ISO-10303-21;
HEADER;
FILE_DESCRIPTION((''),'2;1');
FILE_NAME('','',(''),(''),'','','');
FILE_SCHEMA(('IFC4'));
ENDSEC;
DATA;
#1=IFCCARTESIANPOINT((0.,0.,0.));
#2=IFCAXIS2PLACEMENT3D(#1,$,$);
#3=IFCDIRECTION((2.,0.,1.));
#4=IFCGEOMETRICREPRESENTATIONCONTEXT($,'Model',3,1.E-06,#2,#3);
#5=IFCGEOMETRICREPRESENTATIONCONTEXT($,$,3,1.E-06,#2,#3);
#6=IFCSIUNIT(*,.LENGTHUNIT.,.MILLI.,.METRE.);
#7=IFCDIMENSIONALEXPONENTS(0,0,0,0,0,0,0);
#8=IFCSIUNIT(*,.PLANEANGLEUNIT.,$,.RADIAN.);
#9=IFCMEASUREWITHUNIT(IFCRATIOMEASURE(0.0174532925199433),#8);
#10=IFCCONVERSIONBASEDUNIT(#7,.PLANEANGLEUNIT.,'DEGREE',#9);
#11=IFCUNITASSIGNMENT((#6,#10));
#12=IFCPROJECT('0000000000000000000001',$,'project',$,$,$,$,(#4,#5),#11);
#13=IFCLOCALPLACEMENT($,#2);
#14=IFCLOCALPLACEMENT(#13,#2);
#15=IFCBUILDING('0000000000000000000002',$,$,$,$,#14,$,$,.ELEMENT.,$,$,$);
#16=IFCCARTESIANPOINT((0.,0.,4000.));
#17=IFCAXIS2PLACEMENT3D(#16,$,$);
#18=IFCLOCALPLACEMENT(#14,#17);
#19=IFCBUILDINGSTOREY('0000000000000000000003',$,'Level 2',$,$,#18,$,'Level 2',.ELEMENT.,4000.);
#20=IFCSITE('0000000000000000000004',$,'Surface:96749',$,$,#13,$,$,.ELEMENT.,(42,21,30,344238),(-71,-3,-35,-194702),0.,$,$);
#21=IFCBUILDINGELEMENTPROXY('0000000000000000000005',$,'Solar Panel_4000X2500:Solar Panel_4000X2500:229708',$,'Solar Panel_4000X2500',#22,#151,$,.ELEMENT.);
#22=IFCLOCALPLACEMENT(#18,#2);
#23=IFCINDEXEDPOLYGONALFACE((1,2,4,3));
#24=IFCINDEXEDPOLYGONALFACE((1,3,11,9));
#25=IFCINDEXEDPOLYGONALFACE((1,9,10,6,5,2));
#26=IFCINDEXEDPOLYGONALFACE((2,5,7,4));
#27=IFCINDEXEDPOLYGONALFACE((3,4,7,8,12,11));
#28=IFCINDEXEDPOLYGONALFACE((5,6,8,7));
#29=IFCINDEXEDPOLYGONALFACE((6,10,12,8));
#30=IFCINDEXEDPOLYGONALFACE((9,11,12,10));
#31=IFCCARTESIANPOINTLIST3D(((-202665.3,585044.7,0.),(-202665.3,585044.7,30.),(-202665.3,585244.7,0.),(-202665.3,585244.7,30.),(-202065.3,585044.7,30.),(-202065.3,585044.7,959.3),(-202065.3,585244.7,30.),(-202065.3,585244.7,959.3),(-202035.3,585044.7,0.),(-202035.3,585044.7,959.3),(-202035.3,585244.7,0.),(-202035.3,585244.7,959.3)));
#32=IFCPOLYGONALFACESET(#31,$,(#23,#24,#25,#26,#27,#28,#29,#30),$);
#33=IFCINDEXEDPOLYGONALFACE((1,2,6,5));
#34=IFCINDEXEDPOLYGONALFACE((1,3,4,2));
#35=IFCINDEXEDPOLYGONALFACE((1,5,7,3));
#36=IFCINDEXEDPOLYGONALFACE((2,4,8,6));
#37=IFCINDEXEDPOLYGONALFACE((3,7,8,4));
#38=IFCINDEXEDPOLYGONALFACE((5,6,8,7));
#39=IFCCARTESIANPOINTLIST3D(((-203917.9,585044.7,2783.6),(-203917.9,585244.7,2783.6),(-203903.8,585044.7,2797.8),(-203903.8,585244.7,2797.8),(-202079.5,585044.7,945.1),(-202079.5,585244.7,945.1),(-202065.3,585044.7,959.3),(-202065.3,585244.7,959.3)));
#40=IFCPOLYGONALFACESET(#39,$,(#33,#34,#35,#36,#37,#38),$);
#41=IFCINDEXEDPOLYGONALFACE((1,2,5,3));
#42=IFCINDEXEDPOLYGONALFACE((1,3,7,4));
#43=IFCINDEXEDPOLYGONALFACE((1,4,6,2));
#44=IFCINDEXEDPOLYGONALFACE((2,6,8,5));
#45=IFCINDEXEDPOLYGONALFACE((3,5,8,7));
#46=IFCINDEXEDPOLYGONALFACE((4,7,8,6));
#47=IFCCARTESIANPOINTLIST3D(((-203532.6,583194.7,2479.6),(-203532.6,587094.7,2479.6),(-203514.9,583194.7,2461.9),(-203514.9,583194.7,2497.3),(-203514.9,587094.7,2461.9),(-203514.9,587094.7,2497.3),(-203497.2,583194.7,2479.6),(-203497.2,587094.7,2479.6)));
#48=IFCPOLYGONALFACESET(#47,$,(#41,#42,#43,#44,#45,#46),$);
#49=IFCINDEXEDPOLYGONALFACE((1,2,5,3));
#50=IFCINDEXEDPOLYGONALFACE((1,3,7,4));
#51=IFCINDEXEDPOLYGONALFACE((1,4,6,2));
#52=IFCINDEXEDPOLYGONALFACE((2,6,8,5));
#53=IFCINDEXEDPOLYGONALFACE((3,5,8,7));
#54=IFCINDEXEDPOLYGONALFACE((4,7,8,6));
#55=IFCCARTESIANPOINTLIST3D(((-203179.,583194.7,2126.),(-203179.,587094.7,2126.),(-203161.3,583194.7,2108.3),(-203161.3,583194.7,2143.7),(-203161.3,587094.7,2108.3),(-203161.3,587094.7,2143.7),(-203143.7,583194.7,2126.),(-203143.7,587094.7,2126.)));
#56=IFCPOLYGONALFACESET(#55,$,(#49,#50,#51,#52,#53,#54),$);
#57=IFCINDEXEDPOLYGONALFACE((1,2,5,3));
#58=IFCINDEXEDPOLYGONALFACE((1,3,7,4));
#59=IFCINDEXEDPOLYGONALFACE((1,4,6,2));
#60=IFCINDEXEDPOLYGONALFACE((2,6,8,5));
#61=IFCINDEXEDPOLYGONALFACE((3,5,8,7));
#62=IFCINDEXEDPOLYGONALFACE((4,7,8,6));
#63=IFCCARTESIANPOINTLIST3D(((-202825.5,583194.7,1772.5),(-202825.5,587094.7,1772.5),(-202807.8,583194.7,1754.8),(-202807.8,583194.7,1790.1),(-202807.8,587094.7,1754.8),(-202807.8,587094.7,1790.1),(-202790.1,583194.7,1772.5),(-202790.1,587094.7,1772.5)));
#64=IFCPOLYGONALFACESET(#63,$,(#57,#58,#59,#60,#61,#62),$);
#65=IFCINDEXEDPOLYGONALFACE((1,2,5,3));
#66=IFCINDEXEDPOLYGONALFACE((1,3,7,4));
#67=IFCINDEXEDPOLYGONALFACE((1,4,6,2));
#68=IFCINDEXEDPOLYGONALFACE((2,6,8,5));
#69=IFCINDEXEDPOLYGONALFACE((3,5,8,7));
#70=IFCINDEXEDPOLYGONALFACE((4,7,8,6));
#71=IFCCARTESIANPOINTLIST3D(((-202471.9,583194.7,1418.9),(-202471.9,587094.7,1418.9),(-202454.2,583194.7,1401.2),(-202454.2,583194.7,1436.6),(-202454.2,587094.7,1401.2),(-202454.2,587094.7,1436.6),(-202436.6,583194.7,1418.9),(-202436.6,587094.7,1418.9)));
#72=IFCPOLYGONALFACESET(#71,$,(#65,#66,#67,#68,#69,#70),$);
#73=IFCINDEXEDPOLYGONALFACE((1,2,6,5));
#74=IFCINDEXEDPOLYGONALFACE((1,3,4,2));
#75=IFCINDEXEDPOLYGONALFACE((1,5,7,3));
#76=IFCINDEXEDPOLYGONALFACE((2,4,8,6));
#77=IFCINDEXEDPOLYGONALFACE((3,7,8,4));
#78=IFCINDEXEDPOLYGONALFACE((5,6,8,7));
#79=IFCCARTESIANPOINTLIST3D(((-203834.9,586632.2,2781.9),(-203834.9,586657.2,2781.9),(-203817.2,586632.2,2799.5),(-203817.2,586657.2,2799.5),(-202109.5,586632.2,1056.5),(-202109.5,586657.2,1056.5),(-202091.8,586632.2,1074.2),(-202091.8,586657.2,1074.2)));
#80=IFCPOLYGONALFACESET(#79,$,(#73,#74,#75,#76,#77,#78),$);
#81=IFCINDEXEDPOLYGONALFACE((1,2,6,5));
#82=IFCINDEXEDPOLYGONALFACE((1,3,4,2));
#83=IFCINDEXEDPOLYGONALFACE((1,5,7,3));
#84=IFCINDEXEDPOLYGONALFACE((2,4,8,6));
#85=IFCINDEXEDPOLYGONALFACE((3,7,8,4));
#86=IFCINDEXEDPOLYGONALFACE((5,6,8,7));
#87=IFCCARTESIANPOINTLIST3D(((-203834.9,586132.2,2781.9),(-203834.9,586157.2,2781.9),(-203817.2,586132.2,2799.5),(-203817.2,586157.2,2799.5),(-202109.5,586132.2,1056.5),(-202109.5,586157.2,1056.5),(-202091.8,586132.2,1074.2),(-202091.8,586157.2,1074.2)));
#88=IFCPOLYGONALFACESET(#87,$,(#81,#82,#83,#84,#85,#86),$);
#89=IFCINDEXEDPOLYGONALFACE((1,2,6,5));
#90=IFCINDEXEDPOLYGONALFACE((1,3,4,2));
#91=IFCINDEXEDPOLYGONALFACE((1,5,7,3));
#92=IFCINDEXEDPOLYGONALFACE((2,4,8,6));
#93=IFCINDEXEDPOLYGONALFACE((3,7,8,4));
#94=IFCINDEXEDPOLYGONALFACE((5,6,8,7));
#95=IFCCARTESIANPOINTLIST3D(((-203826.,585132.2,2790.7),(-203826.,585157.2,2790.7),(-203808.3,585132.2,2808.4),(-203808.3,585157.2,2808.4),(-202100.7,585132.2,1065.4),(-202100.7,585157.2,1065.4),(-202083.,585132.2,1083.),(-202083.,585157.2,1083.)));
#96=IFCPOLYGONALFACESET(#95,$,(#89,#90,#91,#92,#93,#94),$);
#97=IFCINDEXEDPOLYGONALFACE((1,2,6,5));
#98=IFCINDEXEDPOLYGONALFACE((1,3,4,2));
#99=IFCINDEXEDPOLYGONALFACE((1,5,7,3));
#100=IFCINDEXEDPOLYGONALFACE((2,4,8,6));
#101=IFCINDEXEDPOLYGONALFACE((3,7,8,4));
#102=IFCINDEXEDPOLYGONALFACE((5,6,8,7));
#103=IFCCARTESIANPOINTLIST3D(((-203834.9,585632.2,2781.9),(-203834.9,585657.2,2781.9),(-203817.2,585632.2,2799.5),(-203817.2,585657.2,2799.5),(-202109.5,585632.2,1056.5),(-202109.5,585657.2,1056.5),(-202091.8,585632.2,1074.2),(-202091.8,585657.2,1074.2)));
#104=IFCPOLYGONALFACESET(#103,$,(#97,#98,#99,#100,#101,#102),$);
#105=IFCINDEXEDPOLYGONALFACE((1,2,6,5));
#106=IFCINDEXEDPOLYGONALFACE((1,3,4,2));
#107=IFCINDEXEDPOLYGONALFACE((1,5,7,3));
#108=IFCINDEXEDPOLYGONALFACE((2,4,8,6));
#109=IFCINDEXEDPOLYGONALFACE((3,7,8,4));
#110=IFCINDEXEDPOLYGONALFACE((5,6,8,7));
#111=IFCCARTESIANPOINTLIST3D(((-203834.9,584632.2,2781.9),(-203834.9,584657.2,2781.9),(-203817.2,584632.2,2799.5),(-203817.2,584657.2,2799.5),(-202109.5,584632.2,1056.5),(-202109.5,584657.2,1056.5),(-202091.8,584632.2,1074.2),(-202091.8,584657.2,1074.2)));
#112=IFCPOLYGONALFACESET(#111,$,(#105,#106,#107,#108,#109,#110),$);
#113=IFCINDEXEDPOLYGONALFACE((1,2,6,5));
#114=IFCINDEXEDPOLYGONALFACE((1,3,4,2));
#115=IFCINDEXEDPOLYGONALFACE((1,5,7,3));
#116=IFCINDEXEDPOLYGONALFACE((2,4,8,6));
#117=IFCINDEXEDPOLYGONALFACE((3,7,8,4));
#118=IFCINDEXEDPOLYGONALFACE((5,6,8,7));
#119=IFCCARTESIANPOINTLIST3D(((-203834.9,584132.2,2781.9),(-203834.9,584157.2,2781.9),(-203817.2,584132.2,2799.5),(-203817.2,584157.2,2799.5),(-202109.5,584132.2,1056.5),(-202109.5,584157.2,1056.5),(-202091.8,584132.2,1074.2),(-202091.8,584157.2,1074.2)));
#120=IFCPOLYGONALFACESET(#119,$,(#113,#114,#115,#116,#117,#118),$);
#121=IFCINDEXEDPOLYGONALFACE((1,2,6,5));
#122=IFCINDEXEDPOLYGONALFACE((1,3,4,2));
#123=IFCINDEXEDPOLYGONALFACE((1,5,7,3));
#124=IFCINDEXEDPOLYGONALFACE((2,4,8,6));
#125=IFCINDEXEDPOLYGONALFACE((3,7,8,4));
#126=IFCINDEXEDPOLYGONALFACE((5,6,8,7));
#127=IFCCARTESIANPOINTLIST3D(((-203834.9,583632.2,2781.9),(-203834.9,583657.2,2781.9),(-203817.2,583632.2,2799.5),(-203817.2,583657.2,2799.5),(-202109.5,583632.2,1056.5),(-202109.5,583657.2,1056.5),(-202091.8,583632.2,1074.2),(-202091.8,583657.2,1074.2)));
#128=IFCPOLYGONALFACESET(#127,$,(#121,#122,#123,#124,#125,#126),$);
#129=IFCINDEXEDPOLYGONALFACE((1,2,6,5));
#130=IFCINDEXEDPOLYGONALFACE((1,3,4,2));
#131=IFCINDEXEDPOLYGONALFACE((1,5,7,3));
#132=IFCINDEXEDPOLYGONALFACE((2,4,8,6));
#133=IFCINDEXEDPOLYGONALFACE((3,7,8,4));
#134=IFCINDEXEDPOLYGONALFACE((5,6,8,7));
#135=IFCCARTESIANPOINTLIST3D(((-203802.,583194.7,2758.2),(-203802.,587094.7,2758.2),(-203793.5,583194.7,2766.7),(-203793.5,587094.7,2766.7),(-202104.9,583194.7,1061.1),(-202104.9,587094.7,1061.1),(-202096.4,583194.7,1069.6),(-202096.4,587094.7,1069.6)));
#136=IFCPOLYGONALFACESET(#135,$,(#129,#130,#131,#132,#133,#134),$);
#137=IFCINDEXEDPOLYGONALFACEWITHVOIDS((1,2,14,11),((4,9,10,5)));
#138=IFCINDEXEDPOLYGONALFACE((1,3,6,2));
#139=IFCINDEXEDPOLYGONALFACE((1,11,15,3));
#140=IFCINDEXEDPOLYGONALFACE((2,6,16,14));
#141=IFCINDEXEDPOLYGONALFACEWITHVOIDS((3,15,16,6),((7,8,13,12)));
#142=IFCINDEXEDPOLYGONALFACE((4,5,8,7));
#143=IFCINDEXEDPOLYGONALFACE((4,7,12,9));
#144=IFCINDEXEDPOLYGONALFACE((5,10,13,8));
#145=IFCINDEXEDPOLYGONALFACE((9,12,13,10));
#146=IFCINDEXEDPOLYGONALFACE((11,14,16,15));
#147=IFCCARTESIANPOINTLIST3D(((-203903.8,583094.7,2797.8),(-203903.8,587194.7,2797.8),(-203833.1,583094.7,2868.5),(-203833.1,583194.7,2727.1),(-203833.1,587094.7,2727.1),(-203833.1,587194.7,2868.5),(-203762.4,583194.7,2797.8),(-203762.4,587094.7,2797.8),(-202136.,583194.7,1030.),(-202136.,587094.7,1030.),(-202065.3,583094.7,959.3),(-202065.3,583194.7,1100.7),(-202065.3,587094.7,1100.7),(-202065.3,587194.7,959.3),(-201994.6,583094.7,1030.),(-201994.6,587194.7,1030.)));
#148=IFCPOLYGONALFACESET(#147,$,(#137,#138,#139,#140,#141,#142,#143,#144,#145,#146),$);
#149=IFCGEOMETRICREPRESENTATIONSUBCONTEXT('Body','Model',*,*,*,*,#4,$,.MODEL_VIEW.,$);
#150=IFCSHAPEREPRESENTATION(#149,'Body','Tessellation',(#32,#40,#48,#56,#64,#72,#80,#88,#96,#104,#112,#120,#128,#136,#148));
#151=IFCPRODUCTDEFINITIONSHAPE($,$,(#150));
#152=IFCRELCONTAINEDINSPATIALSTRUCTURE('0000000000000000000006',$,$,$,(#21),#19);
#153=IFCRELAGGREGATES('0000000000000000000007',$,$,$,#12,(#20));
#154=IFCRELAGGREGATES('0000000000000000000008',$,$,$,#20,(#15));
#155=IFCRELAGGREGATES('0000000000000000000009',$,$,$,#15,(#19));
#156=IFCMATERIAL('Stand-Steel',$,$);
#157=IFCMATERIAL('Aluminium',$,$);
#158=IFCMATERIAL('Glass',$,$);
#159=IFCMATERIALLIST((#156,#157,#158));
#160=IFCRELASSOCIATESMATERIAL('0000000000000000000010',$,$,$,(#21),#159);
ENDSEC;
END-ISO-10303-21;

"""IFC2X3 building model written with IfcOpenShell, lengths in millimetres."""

from ifc_helpers import new_model, entity, si_unit, converted_unit, direction, frame, frame_2d, origin, origin_2d_with_axis, place, context, subcontext, project, spatial, polyline, rectangle, outline, extrude, source, transform, mapped, material, material_list, element, save


model = new_model("IFC2X3")

# Units and contexts
model_context = context("Model", 3, precision=1e-06, world=origin(), true_north=direction((2.0, 0.0, 1.0)))
context_of_model = context(None, 3, precision=1e-06, world=origin(), true_north=direction((2.0, 0.0, 1.0)))
body_context = subcontext(model_context, "Body", "Model", "MODEL_VIEW")
ifc_project = project(units=[si_unit("LENGTHUNIT", "METRE", prefix="MILLI"), converted_unit("PLANEANGLEUNIT", "DEGREE", entity("IfcRatioMeasure", 0.0174532925199433), si_unit("PLANEANGLEUNIT", "RADIAN"), dimensions=[0, 0, 0, 0, 0, 0, 0])], contexts=[model_context, context_of_model])

# Site, building, storey
site_placement = place(None, origin())
site = spatial("IfcSite", under=ifc_project, at=site_placement, Name="Surface:96749", CompositionType="ELEMENT", RefLatitude=(42, 21, 30, 344238), RefLongitude=(-71, -3, -35, -194702), RefElevation=0.0)
building_placement = place(site_placement, origin())
building = spatial("IfcBuilding", under=site, at=building_placement, CompositionType="ELEMENT")
storey_placement = place(building_placement, frame((0.0, 0.0, 4000.0)))
storey = spatial("IfcBuildingStorey", under=building, at=storey_placement, Name="Level 2", LongName="Level 2", CompositionType="ELEMENT", Elevation=4000.0)

# Building element proxy
ifc_material_1 = material(Name="Stand-Steel")
ifc_material_2 = material(Name="Aluminium")
ifc_material_3 = material(Name="Glass")
shared_shape = source(origin(), body_context, "Body", "SweptSolid", [
    extrude(outline(polyline([(-629.5, -220.0), (329.8, -220.0), (329.8, 410.0), (299.8, 410.0), (299.8, -190.0), (-629.5, -190.0), (-629.5, -220.0)])), frame((-190.0, -100.0, 299.8), z_axis=(0.0, 1.0, 0.0), x_axis=(0.0, 0.0, -1.0)), (0.0, 0.0, 1.0), 200.0),
    extrude(rectangle(XDim=20.0, YDim=200.0, at=frame_2d((0.0, 0.0), x_axis=(0.0, 1.0))), frame((-7.1, 0.0, 922.2), z_axis=(-0.707107, 0.0, 0.707107), x_axis=(0.0, 1.0, 0.0)), (0.0, 0.0, 1.0), 2600.0),
    extrude(rectangle(XDim=25.0, YDim=25.0, at=frame_2d((0.0, 0.0), x_axis=(1.0, 0.0))), frame((-1449.6, -1950.0, 2449.6), z_axis=(0.0, 1.0, 0.0), x_axis=(-0.707107, 0.0, -0.707107)), (0.0, 0.0, 1.0), 3900.0),
    extrude(rectangle(XDim=25.0, YDim=25.0, at=origin_2d_with_axis()), frame((-1096.0, -1950.0, 2096.0), z_axis=(0.0, 1.0, 0.0), x_axis=(-0.707107, 0.0, -0.707107)), (0.0, 0.0, 1.0), 3900.0),
    extrude(rectangle(XDim=25.0, YDim=25.0, at=origin_2d_with_axis()), frame((-742.5, -1950.0, 1742.5), z_axis=(0.0, 1.0, 0.0), x_axis=(-0.707107, 0.0, -0.707107)), (0.0, 0.0, 1.0), 3900.0),
    extrude(rectangle(XDim=25.0, YDim=25.0, at=frame_2d((0.0, 0.0), x_axis=(1.0, 0.0))), frame((-388.9, -1950.0, 1388.9), z_axis=(0.0, 1.0, 0.0), x_axis=(-0.707107, 0.0, -0.707107)), (0.0, 0.0, 1.0), 3900.0),
    extrude(rectangle(XDim=25.0, YDim=25.0, at=frame_2d((0.0, 0.0), x_axis=(0.0, 1.0))), frame((-35.4, 1500.0, 1035.4), z_axis=(-0.707107, 0.0, 0.707107), x_axis=(0.0, 1.0, 0.0)), (0.0, 0.0, 1.0), 2440.0),
    extrude(rectangle(XDim=25.0, YDim=25.0, at=frame_2d((0.0, 0.0), x_axis=(0.0, 1.0))), frame((-35.4, 1000.0, 1035.4), z_axis=(-0.707107, 0.0, 0.707107), x_axis=(0.0, 1.0, 0.0)), (0.0, 0.0, 1.0), 2440.0),
    extrude(rectangle(XDim=25.0, YDim=25.0, at=frame_2d((0.0, 0.0), x_axis=(0.0, 1.0))), frame((-26.5, 0.0, 1044.2), z_axis=(-0.707107, 0.0, 0.707107), x_axis=(0.0, -1.0, 0.0)), (0.0, 0.0, 1.0), 2440.0),
    extrude(rectangle(XDim=25.0, YDim=25.0, at=frame_2d((0.0, 0.0), x_axis=(0.0, 1.0))), frame((-35.4, 500.0, 1035.4), z_axis=(-0.707107, 0.0, 0.707107), x_axis=(0.0, 1.0, 0.0)), (0.0, 0.0, 1.0), 2440.0),
    extrude(rectangle(XDim=25.0, YDim=25.0, at=frame_2d((0.0, 0.0), x_axis=(0.0, 1.0))), frame((-35.4, -500.0, 1035.4), z_axis=(-0.707107, 0.0, 0.707107), x_axis=(0.0, 1.0, 0.0)), (0.0, 0.0, 1.0), 2440.0),
    extrude(rectangle(XDim=25.0, YDim=25.0, at=frame_2d((0.0, 0.0), x_axis=(0.0, 1.0))), frame((-35.4, -1000.0, 1035.4), z_axis=(-0.707107, 0.0, 0.707107), x_axis=(0.0, 1.0, 0.0)), (0.0, 0.0, 1.0), 2440.0),
    extrude(rectangle(XDim=25.0, YDim=25.0, at=frame_2d((0.0, 0.0), x_axis=(0.0, 1.0))), frame((-35.4, -1500.0, 1035.4), z_axis=(-0.707107, 0.0, 0.707107), x_axis=(0.0, 1.0, 0.0)), (0.0, 0.0, 1.0), 2440.0),
    extrude(rectangle(XDim=2400.0, YDim=12.0, at=frame_2d((0.0, 0.0), x_axis=(1.0, 0.0))), frame((-883.9, -1950.0, 1883.9), z_axis=(0.0, 1.0, 0.0), x_axis=(0.707107, 0.0, -0.707107)), (0.0, 0.0, 1.0), 3900.0),
    extrude(outline(polyline([(-2050.0, -1300.0), (2050.0, -1300.0), (2050.0, 1300.0), (-2050.0, 1300.0), (-2050.0, -1300.0)]), holes=[polyline([(1950.0, -1200.0), (-1950.0, -1200.0), (-1950.0, 1200.0), (1950.0, 1200.0), (1950.0, -1200.0)])]), frame((-919.2, 0.0, 1848.5), z_axis=(0.707107, 0.0, 0.707107), x_axis=(0.0, 1.0, 0.0)), (0.0, 0.0, 1.0), 100.0),
])
ifc_material_list_1 = material_list([ifc_material_1, ifc_material_2, ifc_material_3])
proxy_1_placement = place(storey_placement, frame((-202065.3, 585144.7, 30.0)))
element("IfcBuildingElementProxy", 1, at=proxy_1_placement, inside=storey, material=ifc_material_list_1, Name="Solar Panel_4000X2500:Solar Panel_4000X2500:229708", ObjectType="Solar Panel_4000X2500", CompositionType="ELEMENT", context=body_context, shape_type="MappedRepresentation", body=[
    mapped(shared_shape, transform((0.0, 0.0, 0.0), scale=1.0)),
])

save(model, "model.ifc")
